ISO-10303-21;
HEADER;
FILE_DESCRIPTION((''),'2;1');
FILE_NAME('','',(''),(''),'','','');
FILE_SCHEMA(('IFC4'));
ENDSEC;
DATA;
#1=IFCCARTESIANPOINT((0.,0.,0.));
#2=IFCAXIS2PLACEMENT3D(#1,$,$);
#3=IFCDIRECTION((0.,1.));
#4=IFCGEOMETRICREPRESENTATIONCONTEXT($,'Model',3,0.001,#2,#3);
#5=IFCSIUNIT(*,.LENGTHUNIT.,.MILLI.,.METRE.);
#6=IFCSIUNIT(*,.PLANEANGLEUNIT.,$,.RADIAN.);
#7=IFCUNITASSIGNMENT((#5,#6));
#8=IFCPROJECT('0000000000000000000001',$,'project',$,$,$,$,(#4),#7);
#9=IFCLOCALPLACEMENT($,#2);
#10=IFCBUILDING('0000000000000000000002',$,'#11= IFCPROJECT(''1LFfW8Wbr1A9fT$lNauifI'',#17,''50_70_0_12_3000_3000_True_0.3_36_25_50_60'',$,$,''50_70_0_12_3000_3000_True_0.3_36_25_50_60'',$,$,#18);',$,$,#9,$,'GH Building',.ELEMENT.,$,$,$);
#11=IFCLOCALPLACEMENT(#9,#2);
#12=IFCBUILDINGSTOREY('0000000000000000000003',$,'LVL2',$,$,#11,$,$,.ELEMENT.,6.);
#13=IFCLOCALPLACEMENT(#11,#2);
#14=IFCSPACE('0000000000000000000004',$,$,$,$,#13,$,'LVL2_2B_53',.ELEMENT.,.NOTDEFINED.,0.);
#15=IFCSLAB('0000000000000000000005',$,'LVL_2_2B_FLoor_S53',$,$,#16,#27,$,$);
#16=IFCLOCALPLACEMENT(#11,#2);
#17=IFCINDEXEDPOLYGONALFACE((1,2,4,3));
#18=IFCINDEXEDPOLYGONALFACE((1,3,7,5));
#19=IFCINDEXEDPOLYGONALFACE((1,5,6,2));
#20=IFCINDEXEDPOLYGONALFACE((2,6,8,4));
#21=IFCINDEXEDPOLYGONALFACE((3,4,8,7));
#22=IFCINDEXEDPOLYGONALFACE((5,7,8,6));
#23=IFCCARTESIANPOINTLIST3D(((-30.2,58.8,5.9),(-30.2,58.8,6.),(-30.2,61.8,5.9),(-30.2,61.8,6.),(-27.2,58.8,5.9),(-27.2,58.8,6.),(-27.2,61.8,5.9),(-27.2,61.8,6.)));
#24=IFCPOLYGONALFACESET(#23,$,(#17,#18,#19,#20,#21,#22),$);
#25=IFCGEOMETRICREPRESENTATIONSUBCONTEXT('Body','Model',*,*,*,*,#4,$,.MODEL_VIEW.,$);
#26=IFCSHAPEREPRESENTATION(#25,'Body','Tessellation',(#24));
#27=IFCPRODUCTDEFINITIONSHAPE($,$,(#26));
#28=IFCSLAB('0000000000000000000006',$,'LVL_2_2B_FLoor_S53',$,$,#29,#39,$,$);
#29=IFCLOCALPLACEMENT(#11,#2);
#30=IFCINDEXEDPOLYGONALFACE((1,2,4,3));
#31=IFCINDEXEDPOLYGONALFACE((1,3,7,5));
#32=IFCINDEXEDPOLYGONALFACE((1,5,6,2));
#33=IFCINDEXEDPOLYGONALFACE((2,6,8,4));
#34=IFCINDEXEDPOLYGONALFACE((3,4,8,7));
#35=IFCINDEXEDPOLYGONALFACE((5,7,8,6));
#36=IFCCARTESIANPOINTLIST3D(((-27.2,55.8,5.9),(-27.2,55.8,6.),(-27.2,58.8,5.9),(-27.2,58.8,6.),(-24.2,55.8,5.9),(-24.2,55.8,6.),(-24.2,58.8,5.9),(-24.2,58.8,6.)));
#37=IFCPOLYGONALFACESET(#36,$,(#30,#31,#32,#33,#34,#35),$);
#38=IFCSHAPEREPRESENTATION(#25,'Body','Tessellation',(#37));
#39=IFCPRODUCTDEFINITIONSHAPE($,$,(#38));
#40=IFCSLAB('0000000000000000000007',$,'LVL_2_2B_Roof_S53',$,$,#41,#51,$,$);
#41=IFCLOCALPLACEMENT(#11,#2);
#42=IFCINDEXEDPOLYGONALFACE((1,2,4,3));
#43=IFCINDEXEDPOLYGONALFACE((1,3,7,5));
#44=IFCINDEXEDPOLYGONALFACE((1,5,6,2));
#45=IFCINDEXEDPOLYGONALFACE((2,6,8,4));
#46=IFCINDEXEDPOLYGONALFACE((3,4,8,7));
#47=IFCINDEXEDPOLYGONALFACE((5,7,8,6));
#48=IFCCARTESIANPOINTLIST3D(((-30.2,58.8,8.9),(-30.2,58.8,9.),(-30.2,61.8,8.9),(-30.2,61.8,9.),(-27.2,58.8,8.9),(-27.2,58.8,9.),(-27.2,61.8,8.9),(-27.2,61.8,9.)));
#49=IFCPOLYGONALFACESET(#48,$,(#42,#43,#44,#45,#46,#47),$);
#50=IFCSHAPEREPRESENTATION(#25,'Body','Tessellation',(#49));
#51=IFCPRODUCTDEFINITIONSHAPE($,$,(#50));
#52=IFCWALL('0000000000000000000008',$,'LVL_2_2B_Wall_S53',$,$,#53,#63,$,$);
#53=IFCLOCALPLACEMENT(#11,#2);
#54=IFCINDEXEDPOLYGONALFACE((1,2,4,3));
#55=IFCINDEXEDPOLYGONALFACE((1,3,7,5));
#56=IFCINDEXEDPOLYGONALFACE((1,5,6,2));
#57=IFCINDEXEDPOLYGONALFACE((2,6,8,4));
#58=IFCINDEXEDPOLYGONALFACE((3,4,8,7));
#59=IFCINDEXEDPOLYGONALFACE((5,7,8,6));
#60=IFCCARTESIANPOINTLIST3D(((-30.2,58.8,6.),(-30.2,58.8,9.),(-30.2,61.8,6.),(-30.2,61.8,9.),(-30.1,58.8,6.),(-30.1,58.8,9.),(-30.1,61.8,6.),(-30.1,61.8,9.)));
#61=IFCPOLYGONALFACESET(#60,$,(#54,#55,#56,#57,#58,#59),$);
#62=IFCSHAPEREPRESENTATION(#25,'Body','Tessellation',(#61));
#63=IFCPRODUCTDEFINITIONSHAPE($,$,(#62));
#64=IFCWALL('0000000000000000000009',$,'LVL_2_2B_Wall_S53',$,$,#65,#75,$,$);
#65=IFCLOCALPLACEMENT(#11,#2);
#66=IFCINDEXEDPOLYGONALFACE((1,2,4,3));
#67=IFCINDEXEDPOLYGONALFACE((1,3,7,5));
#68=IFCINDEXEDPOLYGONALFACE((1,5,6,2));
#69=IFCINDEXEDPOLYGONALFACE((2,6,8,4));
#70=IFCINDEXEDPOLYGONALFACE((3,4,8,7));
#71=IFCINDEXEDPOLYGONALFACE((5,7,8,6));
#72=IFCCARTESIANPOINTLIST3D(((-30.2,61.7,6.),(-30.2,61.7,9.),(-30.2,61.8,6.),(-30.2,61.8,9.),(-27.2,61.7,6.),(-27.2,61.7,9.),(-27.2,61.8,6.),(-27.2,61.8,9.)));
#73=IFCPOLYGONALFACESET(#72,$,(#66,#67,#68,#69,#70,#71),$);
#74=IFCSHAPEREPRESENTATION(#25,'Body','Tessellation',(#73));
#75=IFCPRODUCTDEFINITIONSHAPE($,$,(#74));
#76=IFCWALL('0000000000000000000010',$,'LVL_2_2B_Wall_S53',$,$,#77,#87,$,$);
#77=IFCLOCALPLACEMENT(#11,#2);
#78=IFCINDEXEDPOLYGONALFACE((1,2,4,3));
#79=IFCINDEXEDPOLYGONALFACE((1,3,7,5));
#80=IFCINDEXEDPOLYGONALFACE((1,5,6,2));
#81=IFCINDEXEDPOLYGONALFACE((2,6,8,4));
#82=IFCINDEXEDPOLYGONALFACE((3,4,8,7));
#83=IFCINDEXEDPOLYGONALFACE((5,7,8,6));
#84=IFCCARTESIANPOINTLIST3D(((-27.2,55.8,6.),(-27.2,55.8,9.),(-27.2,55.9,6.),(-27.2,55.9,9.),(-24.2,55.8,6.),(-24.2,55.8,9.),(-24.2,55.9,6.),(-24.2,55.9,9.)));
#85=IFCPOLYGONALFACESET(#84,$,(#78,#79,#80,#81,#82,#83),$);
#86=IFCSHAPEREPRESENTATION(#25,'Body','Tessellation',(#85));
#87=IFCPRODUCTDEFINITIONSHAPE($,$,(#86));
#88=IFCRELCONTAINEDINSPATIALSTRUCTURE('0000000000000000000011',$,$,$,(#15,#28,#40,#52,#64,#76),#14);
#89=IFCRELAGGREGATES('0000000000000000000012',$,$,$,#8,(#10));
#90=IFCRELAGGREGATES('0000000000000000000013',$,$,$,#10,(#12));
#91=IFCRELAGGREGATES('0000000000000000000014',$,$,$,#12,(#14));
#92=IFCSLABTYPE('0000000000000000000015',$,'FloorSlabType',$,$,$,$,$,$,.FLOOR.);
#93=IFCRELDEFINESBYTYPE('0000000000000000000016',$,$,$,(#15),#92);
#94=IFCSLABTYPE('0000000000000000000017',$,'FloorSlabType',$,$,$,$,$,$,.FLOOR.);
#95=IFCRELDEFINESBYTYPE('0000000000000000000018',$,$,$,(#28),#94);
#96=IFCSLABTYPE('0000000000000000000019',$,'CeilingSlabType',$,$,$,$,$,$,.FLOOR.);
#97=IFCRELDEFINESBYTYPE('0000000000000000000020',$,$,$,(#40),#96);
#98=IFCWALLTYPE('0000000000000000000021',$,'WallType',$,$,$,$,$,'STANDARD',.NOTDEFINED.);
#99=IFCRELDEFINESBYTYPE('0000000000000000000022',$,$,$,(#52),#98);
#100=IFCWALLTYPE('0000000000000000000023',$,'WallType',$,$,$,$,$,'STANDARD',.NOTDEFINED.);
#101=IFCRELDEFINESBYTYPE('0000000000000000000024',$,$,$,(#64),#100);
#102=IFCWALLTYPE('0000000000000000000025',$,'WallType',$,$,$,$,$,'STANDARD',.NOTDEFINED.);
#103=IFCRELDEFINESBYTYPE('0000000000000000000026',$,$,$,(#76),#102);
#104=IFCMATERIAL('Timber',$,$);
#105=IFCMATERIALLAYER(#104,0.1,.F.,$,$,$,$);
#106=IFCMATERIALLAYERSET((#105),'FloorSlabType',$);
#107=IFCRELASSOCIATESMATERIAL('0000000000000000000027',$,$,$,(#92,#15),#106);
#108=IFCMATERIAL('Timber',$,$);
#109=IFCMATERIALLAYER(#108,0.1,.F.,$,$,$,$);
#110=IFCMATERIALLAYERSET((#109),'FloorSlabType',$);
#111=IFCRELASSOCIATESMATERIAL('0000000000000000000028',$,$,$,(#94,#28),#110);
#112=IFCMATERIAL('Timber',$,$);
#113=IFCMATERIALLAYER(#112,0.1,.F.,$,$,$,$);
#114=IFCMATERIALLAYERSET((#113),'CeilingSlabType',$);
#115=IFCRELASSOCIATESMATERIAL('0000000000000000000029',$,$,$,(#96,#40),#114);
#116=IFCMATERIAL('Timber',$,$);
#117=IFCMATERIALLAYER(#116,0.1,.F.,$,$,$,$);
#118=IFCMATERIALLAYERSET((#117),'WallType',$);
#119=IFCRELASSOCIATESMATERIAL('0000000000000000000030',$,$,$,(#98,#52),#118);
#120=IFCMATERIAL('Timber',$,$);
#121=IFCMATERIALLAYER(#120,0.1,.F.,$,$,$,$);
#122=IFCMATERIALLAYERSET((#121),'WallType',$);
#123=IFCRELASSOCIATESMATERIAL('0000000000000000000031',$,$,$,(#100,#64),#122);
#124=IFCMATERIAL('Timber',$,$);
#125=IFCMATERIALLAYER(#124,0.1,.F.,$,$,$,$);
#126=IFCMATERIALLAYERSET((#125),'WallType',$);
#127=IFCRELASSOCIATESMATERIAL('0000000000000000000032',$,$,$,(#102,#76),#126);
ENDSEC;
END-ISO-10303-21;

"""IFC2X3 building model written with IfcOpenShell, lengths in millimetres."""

from ifc_helpers import new_model, si_unit, direction, frame, frame_2d, origin, place, context, subcontext, project, spatial, rectangle, extrude, material, layer, layer_set, layer_usage, type_object, element, save


model = new_model("IFC2X3")

# Units and contexts
model_context = context("Model", 3, precision=0.001, world=origin(), true_north=direction((0.0, 1.0)))
body_context = subcontext(model_context, "Body", "Model", "MODEL_VIEW")
ifc_project = project(units=[si_unit("LENGTHUNIT", "METRE", prefix="MILLI"), si_unit("PLANEANGLEUNIT", "RADIAN")], contexts=[model_context])

# Building, storey
building_placement = place(None, origin())
building = spatial("IfcBuilding", under=ifc_project, at=building_placement, Name="#11= IFCPROJECT('1LFfW8Wbr1A9fT$lNauifI',#17,'50_70_0_12_3000_3000_True_0.3_36_25_50_60',$,$,'50_70_0_12_3000_3000_True_0.3_36_25_50_60',$,$,#18);", LongName="GH Building", CompositionType="ELEMENT")
storey_placement = place(building_placement, origin())
storey = spatial("IfcBuildingStorey", under=building, at=storey_placement, Name="LVL2", CompositionType="ELEMENT", Elevation=6.0)

# Shared definitions
space_1_placement = place(storey_placement, origin())
space_1 = spatial("IfcSpace", under=storey, at=space_1_placement, LongName="LVL2_2B_53", CompositionType="ELEMENT", InteriorOrExteriorSpace="NOTDEFINED", ElevationWithFlooring=0.0)

# Slabs
ifc_material_1 = material(Name="Timber")
ifc_layer_1 = layer(ifc_material_1, 0.1, ventilated=False)
ifc_layer_set_1 = layer_set([ifc_layer_1], Name="FloorSlabType")
ifc_layer_usage_1 = layer_usage(ifc_layer_set_1, "AXIS3", "NEGATIVE", -0.1)
slab_type_1 = type_object("IfcSlabType", Name="FloorSlabType", PredefinedType="FLOOR", material=ifc_layer_set_1)
slab_1_placement = place(space_1_placement, frame((-27.2, 58.8, 5.9), z_axis=(0.0, 0.0, 1.0), x_axis=(0.0, 1.0, 0.0)))
element("IfcSlab", 1, at=slab_1_placement, inside=space_1, type_object=slab_type_1, material=ifc_layer_usage_1, Name="LVL_2_2B_FLoor_S53", context=body_context, shape_type="SweptSolid", body=[
    extrude(rectangle(XDim=3.0, YDim=3.0, at=frame_2d((1.5, 1.5))), origin(), (0.0, 0.0, 1.0), 0.1),
])
ifc_material_2 = material(Name="Timber")
ifc_layer_2 = layer(ifc_material_2, 0.1, ventilated=False)
ifc_layer_set_2 = layer_set([ifc_layer_2], Name="FloorSlabType")
ifc_layer_usage_2 = layer_usage(ifc_layer_set_2, "AXIS3", "NEGATIVE", -0.1)
slab_type_2 = type_object("IfcSlabType", Name="FloorSlabType", PredefinedType="FLOOR", material=ifc_layer_set_2)
slab_2_placement = place(space_1_placement, frame((-24.2, 55.8, 5.9), z_axis=(0.0, 0.0, 1.0), x_axis=(0.0, 1.0, 0.0)))
element("IfcSlab", 2, at=slab_2_placement, inside=space_1, type_object=slab_type_2, material=ifc_layer_usage_2, Name="LVL_2_2B_FLoor_S53", context=body_context, shape_type="SweptSolid", body=[
    extrude(rectangle(XDim=3.0, YDim=3.0, at=frame_2d((1.5, 1.5))), origin(), (0.0, 0.0, 1.0), 0.1),
])
ifc_material_3 = material(Name="Timber")
ifc_layer_3 = layer(ifc_material_3, 0.1, ventilated=False)
ifc_layer_set_3 = layer_set([ifc_layer_3], Name="CeilingSlabType")
ifc_layer_usage_3 = layer_usage(ifc_layer_set_3, "AXIS3", "NEGATIVE", -0.1)
slab_type_3 = type_object("IfcSlabType", Name="CeilingSlabType", PredefinedType="FLOOR", material=ifc_layer_set_3)
slab_3_placement = place(space_1_placement, frame((-27.2, 58.8, 8.9), z_axis=(0.0, 0.0, 1.0), x_axis=(0.0, 1.0, 0.0)))
element("IfcSlab", 3, at=slab_3_placement, inside=space_1, type_object=slab_type_3, material=ifc_layer_usage_3, Name="LVL_2_2B_Roof_S53", context=body_context, shape_type="SweptSolid", body=[
    extrude(rectangle(XDim=3.0, YDim=3.0, at=frame_2d((1.5, 1.5))), origin(), (0.0, 0.0, 1.0), 0.1),
])

# Walls
ifc_material_4 = material(Name="Timber")
ifc_layer_4 = layer(ifc_material_4, 0.1, ventilated=False)
ifc_layer_set_4 = layer_set([ifc_layer_4], Name="WallType")
ifc_layer_usage_4 = layer_usage(ifc_layer_set_4, "AXIS2", "NEGATIVE", 0.0)
wall_type_1 = type_object("IfcWallType", Name="WallType", ElementType="STANDARD", PredefinedType="NOTDEFINED", material=ifc_layer_set_4)
wall_1_placement = place(space_1_placement, frame((-30.2, 58.8, 6.0), z_axis=(0.0, 0.0, 1.0), x_axis=(0.0, 1.0, 0.0)))
element("IfcWall", 4, at=wall_1_placement, inside=space_1, type_object=wall_type_1, material=ifc_layer_usage_4, Name="LVL_2_2B_Wall_S53", context=body_context, shape_type="SweptSolid", body=[
    extrude(rectangle(XDim=3.0, YDim=0.1, at=frame_2d((1.5, -0.1))), origin(), (0.0, 0.0, 1.0), 3.0),
])
ifc_material_5 = material(Name="Timber")
ifc_layer_5 = layer(ifc_material_5, 0.1, ventilated=False)
ifc_layer_set_5 = layer_set([ifc_layer_5], Name="WallType")
ifc_layer_usage_5 = layer_usage(ifc_layer_set_5, "AXIS2", "NEGATIVE", 0.0)
wall_type_2 = type_object("IfcWallType", Name="WallType", ElementType="STANDARD", PredefinedType="NOTDEFINED", material=ifc_layer_set_5)
wall_2_placement = place(space_1_placement, frame((-30.2, 61.8, 6.0)))
element("IfcWall", 5, at=wall_2_placement, inside=space_1, type_object=wall_type_2, material=ifc_layer_usage_5, Name="LVL_2_2B_Wall_S53", context=body_context, shape_type="SweptSolid", body=[
    extrude(rectangle(XDim=3.0, YDim=0.1, at=frame_2d((1.5, -0.1))), origin(), (0.0, 0.0, 1.0), 3.0),
])
ifc_material_6 = material(Name="Timber")
ifc_layer_6 = layer(ifc_material_6, 0.1, ventilated=False)
ifc_layer_set_6 = layer_set([ifc_layer_6], Name="WallType")
ifc_layer_usage_6 = layer_usage(ifc_layer_set_6, "AXIS2", "NEGATIVE", 0.0)
wall_type_3 = type_object("IfcWallType", Name="WallType", ElementType="STANDARD", PredefinedType="NOTDEFINED", material=ifc_layer_set_6)
wall_3_placement = place(space_1_placement, frame((-24.2, 55.8, 6.0), z_axis=(0.0, 0.0, 1.0), x_axis=(-1.0, 0.0, 0.0)))
element("IfcWall", 6, at=wall_3_placement, inside=space_1, type_object=wall_type_3, material=ifc_layer_usage_6, Name="LVL_2_2B_Wall_S53", context=body_context, shape_type="SweptSolid", body=[
    extrude(rectangle(XDim=3.0, YDim=0.1, at=frame_2d((1.5, -0.1))), origin(), (0.0, 0.0, 1.0), 3.0),
])

save(model, "model.ifc")
